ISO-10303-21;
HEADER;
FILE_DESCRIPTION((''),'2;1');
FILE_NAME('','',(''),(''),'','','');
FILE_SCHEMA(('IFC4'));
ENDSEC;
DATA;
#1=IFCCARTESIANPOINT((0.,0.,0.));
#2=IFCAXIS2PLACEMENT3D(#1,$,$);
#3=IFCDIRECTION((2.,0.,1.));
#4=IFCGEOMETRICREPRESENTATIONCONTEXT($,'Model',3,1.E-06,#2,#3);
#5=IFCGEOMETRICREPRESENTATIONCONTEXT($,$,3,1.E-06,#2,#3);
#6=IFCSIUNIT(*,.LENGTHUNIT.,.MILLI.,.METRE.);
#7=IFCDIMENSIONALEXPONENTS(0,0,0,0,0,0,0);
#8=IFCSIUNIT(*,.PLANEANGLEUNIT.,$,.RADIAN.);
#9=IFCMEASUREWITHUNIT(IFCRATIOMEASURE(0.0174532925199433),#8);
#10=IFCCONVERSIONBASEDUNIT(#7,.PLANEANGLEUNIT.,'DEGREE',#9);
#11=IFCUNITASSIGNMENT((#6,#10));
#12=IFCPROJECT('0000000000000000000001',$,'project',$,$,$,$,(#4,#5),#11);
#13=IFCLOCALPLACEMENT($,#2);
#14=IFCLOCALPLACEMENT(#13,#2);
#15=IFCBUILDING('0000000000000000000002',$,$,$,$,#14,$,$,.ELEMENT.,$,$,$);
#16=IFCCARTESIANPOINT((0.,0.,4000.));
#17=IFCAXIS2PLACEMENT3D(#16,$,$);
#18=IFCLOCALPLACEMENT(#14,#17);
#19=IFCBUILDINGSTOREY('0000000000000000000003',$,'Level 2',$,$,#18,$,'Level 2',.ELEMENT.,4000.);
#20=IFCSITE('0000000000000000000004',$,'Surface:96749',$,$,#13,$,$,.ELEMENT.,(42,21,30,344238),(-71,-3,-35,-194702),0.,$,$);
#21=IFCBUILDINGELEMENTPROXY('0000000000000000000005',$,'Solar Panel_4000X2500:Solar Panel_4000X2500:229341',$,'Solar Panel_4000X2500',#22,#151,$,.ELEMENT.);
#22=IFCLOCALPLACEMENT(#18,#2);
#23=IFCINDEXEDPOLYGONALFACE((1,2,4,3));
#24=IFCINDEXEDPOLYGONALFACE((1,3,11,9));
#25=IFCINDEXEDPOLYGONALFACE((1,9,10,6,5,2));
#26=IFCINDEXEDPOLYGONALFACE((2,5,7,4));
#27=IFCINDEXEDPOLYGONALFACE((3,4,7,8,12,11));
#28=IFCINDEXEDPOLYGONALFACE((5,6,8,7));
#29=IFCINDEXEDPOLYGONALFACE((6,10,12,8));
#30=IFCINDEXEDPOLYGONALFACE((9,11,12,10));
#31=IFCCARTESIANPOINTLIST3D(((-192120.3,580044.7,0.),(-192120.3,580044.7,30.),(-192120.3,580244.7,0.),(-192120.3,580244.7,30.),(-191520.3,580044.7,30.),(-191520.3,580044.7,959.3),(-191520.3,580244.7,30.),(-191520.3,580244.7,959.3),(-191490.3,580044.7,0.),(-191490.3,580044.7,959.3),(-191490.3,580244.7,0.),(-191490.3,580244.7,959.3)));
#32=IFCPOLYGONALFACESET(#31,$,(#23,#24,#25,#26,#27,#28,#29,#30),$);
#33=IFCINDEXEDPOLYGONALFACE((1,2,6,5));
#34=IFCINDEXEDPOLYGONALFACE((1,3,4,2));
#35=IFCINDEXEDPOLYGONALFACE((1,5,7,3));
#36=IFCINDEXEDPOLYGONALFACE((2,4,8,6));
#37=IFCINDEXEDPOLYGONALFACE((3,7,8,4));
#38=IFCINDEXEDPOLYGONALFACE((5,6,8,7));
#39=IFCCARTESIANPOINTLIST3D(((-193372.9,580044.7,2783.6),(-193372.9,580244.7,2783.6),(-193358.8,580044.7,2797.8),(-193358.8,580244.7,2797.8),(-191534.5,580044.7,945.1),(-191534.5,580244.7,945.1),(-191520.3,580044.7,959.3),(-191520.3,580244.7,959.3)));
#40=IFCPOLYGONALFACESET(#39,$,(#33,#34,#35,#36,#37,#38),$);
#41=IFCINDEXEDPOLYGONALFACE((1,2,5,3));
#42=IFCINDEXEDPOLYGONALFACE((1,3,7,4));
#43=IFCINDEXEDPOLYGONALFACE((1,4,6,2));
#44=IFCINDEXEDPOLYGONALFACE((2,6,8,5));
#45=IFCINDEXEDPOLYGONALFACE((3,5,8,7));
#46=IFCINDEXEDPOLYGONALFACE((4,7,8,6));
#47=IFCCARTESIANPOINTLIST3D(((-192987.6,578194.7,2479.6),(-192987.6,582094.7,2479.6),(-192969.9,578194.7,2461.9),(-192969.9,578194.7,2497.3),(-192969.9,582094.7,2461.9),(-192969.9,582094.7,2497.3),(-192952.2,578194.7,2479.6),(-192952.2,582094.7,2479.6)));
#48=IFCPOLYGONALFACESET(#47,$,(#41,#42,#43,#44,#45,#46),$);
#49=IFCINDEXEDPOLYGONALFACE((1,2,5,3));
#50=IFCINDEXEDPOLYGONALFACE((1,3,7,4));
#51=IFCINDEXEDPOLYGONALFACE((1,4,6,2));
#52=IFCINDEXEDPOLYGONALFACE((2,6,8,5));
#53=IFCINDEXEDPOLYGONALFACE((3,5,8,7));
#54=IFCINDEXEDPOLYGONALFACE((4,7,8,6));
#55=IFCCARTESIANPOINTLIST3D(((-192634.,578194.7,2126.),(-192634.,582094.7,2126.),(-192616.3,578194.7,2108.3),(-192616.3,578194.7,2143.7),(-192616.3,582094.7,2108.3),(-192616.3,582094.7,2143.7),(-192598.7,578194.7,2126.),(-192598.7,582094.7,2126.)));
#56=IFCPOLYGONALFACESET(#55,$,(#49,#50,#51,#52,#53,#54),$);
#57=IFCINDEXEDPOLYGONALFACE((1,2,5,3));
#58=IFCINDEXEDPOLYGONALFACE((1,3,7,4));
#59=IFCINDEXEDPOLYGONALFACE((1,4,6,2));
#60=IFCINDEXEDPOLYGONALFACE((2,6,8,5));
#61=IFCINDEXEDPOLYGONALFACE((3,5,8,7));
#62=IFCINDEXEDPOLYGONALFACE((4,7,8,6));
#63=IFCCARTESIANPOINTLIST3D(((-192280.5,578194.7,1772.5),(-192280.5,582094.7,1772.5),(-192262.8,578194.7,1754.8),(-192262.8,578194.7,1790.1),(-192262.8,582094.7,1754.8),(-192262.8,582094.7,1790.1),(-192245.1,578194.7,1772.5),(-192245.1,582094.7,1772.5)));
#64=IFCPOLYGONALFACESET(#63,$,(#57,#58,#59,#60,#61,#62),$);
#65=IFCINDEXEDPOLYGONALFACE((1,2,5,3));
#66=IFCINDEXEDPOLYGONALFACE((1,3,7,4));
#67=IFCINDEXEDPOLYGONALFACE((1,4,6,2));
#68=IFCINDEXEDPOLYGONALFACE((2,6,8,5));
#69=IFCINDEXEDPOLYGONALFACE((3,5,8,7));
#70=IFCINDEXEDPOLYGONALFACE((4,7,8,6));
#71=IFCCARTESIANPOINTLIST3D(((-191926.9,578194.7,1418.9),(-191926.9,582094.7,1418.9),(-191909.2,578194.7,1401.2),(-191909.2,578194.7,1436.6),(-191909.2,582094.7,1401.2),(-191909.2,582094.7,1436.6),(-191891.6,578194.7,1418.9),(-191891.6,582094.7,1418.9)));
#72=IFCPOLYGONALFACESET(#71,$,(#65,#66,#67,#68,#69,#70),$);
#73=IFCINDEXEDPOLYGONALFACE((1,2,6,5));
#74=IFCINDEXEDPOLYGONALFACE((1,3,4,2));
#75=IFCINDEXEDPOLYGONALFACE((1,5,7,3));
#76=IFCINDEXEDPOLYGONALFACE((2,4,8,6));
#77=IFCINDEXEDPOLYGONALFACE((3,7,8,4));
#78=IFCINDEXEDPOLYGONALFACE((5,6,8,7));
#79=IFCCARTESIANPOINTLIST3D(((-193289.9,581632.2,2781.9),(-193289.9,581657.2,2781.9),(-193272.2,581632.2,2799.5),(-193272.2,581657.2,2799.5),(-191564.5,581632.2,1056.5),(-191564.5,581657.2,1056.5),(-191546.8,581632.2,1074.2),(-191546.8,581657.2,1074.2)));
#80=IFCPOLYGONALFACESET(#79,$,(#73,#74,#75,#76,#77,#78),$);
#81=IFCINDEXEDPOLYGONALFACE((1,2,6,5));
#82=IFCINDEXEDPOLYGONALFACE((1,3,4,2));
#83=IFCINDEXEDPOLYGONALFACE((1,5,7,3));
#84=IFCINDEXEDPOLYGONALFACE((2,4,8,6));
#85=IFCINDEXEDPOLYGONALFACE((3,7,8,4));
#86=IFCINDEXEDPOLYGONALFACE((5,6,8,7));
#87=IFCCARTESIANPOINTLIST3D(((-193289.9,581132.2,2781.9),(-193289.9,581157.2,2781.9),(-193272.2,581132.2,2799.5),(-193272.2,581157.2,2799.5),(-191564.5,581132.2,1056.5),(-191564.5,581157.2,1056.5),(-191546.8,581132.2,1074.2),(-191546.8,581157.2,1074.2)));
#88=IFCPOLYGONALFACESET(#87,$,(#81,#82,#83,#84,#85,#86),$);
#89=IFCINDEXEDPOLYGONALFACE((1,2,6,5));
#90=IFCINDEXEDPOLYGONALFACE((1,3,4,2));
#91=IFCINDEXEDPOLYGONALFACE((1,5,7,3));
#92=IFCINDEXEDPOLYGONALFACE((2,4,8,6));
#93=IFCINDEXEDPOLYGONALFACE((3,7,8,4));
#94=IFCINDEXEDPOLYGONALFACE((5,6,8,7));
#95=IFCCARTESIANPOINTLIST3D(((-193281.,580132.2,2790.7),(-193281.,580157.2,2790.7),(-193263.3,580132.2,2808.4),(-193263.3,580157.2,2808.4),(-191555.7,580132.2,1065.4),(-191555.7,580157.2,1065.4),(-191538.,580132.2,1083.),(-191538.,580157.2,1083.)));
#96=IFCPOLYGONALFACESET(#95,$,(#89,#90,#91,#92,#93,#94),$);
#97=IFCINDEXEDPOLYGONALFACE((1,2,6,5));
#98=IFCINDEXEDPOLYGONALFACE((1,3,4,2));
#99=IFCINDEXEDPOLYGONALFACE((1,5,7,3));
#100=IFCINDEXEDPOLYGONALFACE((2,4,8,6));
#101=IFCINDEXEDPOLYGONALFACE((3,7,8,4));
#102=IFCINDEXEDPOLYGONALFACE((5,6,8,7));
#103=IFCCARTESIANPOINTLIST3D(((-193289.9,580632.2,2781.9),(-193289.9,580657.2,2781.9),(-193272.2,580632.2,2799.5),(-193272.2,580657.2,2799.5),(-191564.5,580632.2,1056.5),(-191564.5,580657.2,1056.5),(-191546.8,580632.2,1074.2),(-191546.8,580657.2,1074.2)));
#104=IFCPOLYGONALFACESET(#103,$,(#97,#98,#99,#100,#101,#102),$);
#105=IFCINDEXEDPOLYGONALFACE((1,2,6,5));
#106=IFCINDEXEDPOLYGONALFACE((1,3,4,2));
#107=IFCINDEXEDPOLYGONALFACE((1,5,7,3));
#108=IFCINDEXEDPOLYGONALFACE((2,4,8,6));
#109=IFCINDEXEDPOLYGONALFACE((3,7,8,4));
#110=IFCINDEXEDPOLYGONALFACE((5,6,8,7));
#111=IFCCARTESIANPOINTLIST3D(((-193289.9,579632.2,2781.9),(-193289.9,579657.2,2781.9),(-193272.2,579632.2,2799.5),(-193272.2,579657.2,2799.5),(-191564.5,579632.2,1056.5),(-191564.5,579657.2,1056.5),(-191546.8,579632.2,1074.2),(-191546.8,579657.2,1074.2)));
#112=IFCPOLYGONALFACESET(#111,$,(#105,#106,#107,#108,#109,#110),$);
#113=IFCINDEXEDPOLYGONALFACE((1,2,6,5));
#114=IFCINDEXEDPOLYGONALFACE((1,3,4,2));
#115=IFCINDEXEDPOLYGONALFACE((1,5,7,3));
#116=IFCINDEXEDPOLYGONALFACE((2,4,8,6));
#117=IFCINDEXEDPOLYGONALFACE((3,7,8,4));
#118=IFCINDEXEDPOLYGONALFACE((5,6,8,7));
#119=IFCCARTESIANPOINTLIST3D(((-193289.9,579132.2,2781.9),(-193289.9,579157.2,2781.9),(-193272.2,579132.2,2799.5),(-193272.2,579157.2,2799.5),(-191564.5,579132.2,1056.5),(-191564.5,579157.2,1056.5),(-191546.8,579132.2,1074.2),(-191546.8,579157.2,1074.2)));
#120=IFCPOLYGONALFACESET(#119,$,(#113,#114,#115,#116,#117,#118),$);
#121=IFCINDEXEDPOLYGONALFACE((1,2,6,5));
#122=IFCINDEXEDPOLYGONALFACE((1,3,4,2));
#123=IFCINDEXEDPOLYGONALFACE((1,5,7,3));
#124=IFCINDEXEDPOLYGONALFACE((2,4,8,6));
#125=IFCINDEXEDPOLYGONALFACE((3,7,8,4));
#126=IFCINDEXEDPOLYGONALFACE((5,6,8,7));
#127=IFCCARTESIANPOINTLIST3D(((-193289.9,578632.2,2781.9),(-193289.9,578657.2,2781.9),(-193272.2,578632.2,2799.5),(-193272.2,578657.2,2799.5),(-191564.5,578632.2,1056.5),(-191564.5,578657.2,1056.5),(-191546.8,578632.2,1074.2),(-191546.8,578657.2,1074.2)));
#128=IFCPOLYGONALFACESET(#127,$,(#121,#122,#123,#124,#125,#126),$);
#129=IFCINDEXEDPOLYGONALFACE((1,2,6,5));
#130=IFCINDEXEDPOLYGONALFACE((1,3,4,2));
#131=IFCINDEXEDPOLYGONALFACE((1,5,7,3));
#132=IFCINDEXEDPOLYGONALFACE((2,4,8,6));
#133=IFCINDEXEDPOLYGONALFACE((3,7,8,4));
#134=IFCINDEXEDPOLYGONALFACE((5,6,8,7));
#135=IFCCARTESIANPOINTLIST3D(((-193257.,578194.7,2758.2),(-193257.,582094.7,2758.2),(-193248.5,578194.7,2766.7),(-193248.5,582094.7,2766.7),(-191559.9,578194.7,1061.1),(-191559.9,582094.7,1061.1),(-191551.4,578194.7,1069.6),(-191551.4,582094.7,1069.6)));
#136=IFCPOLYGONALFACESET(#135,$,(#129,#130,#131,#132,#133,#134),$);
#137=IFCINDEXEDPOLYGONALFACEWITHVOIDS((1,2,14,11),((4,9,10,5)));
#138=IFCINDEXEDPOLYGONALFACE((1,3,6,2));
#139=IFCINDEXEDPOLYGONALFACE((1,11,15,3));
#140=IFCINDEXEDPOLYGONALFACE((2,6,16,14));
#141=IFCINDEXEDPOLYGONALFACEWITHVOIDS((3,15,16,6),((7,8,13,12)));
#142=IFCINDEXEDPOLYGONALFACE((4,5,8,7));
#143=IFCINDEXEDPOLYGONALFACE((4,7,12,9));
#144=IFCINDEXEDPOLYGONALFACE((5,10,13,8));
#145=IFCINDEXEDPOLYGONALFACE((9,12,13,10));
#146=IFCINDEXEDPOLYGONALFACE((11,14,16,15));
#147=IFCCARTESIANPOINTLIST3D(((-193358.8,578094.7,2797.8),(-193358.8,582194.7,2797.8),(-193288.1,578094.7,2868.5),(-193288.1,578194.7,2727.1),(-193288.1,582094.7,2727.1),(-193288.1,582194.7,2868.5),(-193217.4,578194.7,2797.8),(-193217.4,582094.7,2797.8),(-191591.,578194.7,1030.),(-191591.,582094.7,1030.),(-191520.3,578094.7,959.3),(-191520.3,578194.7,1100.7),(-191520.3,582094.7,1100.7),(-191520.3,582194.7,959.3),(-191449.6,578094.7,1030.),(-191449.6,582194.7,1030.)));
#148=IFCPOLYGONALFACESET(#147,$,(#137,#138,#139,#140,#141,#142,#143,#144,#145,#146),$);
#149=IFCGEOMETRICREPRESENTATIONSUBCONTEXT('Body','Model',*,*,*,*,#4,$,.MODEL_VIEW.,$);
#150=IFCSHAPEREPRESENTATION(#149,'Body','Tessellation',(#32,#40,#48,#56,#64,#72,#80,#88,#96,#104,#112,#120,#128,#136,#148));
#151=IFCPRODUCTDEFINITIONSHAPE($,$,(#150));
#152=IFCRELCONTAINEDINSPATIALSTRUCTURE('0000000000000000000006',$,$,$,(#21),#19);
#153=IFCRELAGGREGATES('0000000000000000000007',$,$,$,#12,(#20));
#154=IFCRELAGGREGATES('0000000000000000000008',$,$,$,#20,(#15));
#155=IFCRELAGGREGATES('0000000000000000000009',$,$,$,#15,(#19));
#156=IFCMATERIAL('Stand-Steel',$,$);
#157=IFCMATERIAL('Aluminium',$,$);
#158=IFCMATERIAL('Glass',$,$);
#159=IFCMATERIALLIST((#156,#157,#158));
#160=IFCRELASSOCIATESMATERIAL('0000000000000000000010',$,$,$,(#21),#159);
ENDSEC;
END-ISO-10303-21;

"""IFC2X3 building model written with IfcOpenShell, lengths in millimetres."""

from ifc_helpers import new_model, entity, si_unit, converted_unit, direction, frame, frame_2d, origin, origin_2d_with_axis, place, context, subcontext, project, spatial, polyline, rectangle, outline, extrude, source, transform, mapped, material, material_list, element, save


model = new_model("IFC2X3")

# Units and contexts
model_context = context("Model", 3, precision=1e-06, world=origin(), true_north=direction((2.0, 0.0, 1.0)))
context_of_model = context(None, 3, precision=1e-06, world=origin(), true_north=direction((2.0, 0.0, 1.0)))
body_context = subcontext(model_context, "Body", "Model", "MODEL_VIEW")
ifc_project = project(units=[si_unit("LENGTHUNIT", "METRE", prefix="MILLI"), converted_unit("PLANEANGLEUNIT", "DEGREE", entity("IfcRatioMeasure", 0.0174532925199433), si_unit("PLANEANGLEUNIT", "RADIAN"), dimensions=[0, 0, 0, 0, 0, 0, 0])], contexts=[model_context, context_of_model])

# Site, building, storey
site_placement = place(None, origin())
site = spatial("IfcSite", under=ifc_project, at=site_placement, Name="Surface:96749", CompositionType="ELEMENT", RefLatitude=(42, 21, 30, 344238), RefLongitude=(-71, -3, -35, -194702), RefElevation=0.0)
building_placement = place(site_placement, origin())
building = spatial("IfcBuilding", under=site, at=building_placement, CompositionType="ELEMENT")
storey_placement = place(building_placement, frame((0.0, 0.0, 4000.0)))
storey = spatial("IfcBuildingStorey", under=building, at=storey_placement, Name="Level 2", LongName="Level 2", CompositionType="ELEMENT", Elevation=4000.0)

# Building element proxy
ifc_material_1 = material(Name="Stand-Steel")
ifc_material_2 = material(Name="Aluminium")
ifc_material_3 = material(Name="Glass")
shared_shape = source(origin(), body_context, "Body", "SweptSolid", [
    extrude(outline(polyline([(-629.5, -220.0), (329.8, -220.0), (329.8, 410.0), (299.8, 410.0), (299.8, -190.0), (-629.5, -190.0), (-629.5, -220.0)])), frame((-190.0, -100.0, 299.8), z_axis=(0.0, 1.0, 0.0), x_axis=(0.0, 0.0, -1.0)), (0.0, 0.0, 1.0), 200.0),
    extrude(rectangle(XDim=20.0, YDim=200.0, at=frame_2d((0.0, 0.0), x_axis=(0.0, 1.0))), frame((-7.1, 0.0, 922.2), z_axis=(-0.707107, 0.0, 0.707107), x_axis=(0.0, 1.0, 0.0)), (0.0, 0.0, 1.0), 2600.0),
    extrude(rectangle(XDim=25.0, YDim=25.0, at=frame_2d((0.0, 0.0), x_axis=(1.0, 0.0))), frame((-1449.6, -1950.0, 2449.6), z_axis=(0.0, 1.0, 0.0), x_axis=(-0.707107, 0.0, -0.707107)), (0.0, 0.0, 1.0), 3900.0),
    extrude(rectangle(XDim=25.0, YDim=25.0, at=origin_2d_with_axis()), frame((-1096.0, -1950.0, 2096.0), z_axis=(0.0, 1.0, 0.0), x_axis=(-0.707107, 0.0, -0.707107)), (0.0, 0.0, 1.0), 3900.0),
    extrude(rectangle(XDim=25.0, YDim=25.0, at=origin_2d_with_axis()), frame((-742.5, -1950.0, 1742.5), z_axis=(0.0, 1.0, 0.0), x_axis=(-0.707107, 0.0, -0.707107)), (0.0, 0.0, 1.0), 3900.0),
    extrude(rectangle(XDim=25.0, YDim=25.0, at=frame_2d((0.0, 0.0), x_axis=(1.0, 0.0))), frame((-388.9, -1950.0, 1388.9), z_axis=(0.0, 1.0, 0.0), x_axis=(-0.707107, 0.0, -0.707107)), (0.0, 0.0, 1.0), 3900.0),
    extrude(rectangle(XDim=25.0, YDim=25.0, at=frame_2d((0.0, 0.0), x_axis=(0.0, 1.0))), frame((-35.4, 1500.0, 1035.4), z_axis=(-0.707107, 0.0, 0.707107), x_axis=(0.0, 1.0, 0.0)), (0.0, 0.0, 1.0), 2440.0),
    extrude(rectangle(XDim=25.0, YDim=25.0, at=frame_2d((0.0, 0.0), x_axis=(0.0, 1.0))), frame((-35.4, 1000.0, 1035.4), z_axis=(-0.707107, 0.0, 0.707107), x_axis=(0.0, 1.0, 0.0)), (0.0, 0.0, 1.0), 2440.0),
    extrude(rectangle(XDim=25.0, YDim=25.0, at=frame_2d((0.0, 0.0), x_axis=(0.0, 1.0))), frame((-26.5, 0.0, 1044.2), z_axis=(-0.707107, 0.0, 0.707107), x_axis=(0.0, -1.0, 0.0)), (0.0, 0.0, 1.0), 2440.0),
    extrude(rectangle(XDim=25.0, YDim=25.0, at=frame_2d((0.0, 0.0), x_axis=(0.0, 1.0))), frame((-35.4, 500.0, 1035.4), z_axis=(-0.707107, 0.0, 0.707107), x_axis=(0.0, 1.0, 0.0)), (0.0, 0.0, 1.0), 2440.0),
    extrude(rectangle(XDim=25.0, YDim=25.0, at=frame_2d((0.0, 0.0), x_axis=(0.0, 1.0))), frame((-35.4, -500.0, 1035.4), z_axis=(-0.707107, 0.0, 0.707107), x_axis=(0.0, 1.0, 0.0)), (0.0, 0.0, 1.0), 2440.0),
    extrude(rectangle(XDim=25.0, YDim=25.0, at=frame_2d((0.0, 0.0), x_axis=(0.0, 1.0))), frame((-35.4, -1000.0, 1035.4), z_axis=(-0.707107, 0.0, 0.707107), x_axis=(0.0, 1.0, 0.0)), (0.0, 0.0, 1.0), 2440.0),
    extrude(rectangle(XDim=25.0, YDim=25.0, at=frame_2d((0.0, 0.0), x_axis=(0.0, 1.0))), frame((-35.4, -1500.0, 1035.4), z_axis=(-0.707107, 0.0, 0.707107), x_axis=(0.0, 1.0, 0.0)), (0.0, 0.0, 1.0), 2440.0),
    extrude(rectangle(XDim=2400.0, YDim=12.0, at=frame_2d((0.0, 0.0), x_axis=(1.0, 0.0))), frame((-883.9, -1950.0, 1883.9), z_axis=(0.0, 1.0, 0.0), x_axis=(0.707107, 0.0, -0.707107)), (0.0, 0.0, 1.0), 3900.0),
    extrude(outline(polyline([(-2050.0, -1300.0), (2050.0, -1300.0), (2050.0, 1300.0), (-2050.0, 1300.0), (-2050.0, -1300.0)]), holes=[polyline([(1950.0, -1200.0), (-1950.0, -1200.0), (-1950.0, 1200.0), (1950.0, 1200.0), (1950.0, -1200.0)])]), frame((-919.2, 0.0, 1848.5), z_axis=(0.707107, 0.0, 0.707107), x_axis=(0.0, 1.0, 0.0)), (0.0, 0.0, 1.0), 100.0),
])
ifc_material_list_1 = material_list([ifc_material_1, ifc_material_2, ifc_material_3])
proxy_1_placement = place(storey_placement, frame((-191520.3, 580144.7, 30.0)))
element("IfcBuildingElementProxy", 1, at=proxy_1_placement, inside=storey, material=ifc_material_list_1, Name="Solar Panel_4000X2500:Solar Panel_4000X2500:229341", ObjectType="Solar Panel_4000X2500", CompositionType="ELEMENT", context=body_context, shape_type="MappedRepresentation", body=[
    mapped(shared_shape, transform((0.0, 0.0, 0.0), scale=1.0)),
])

save(model, "model.ifc")
